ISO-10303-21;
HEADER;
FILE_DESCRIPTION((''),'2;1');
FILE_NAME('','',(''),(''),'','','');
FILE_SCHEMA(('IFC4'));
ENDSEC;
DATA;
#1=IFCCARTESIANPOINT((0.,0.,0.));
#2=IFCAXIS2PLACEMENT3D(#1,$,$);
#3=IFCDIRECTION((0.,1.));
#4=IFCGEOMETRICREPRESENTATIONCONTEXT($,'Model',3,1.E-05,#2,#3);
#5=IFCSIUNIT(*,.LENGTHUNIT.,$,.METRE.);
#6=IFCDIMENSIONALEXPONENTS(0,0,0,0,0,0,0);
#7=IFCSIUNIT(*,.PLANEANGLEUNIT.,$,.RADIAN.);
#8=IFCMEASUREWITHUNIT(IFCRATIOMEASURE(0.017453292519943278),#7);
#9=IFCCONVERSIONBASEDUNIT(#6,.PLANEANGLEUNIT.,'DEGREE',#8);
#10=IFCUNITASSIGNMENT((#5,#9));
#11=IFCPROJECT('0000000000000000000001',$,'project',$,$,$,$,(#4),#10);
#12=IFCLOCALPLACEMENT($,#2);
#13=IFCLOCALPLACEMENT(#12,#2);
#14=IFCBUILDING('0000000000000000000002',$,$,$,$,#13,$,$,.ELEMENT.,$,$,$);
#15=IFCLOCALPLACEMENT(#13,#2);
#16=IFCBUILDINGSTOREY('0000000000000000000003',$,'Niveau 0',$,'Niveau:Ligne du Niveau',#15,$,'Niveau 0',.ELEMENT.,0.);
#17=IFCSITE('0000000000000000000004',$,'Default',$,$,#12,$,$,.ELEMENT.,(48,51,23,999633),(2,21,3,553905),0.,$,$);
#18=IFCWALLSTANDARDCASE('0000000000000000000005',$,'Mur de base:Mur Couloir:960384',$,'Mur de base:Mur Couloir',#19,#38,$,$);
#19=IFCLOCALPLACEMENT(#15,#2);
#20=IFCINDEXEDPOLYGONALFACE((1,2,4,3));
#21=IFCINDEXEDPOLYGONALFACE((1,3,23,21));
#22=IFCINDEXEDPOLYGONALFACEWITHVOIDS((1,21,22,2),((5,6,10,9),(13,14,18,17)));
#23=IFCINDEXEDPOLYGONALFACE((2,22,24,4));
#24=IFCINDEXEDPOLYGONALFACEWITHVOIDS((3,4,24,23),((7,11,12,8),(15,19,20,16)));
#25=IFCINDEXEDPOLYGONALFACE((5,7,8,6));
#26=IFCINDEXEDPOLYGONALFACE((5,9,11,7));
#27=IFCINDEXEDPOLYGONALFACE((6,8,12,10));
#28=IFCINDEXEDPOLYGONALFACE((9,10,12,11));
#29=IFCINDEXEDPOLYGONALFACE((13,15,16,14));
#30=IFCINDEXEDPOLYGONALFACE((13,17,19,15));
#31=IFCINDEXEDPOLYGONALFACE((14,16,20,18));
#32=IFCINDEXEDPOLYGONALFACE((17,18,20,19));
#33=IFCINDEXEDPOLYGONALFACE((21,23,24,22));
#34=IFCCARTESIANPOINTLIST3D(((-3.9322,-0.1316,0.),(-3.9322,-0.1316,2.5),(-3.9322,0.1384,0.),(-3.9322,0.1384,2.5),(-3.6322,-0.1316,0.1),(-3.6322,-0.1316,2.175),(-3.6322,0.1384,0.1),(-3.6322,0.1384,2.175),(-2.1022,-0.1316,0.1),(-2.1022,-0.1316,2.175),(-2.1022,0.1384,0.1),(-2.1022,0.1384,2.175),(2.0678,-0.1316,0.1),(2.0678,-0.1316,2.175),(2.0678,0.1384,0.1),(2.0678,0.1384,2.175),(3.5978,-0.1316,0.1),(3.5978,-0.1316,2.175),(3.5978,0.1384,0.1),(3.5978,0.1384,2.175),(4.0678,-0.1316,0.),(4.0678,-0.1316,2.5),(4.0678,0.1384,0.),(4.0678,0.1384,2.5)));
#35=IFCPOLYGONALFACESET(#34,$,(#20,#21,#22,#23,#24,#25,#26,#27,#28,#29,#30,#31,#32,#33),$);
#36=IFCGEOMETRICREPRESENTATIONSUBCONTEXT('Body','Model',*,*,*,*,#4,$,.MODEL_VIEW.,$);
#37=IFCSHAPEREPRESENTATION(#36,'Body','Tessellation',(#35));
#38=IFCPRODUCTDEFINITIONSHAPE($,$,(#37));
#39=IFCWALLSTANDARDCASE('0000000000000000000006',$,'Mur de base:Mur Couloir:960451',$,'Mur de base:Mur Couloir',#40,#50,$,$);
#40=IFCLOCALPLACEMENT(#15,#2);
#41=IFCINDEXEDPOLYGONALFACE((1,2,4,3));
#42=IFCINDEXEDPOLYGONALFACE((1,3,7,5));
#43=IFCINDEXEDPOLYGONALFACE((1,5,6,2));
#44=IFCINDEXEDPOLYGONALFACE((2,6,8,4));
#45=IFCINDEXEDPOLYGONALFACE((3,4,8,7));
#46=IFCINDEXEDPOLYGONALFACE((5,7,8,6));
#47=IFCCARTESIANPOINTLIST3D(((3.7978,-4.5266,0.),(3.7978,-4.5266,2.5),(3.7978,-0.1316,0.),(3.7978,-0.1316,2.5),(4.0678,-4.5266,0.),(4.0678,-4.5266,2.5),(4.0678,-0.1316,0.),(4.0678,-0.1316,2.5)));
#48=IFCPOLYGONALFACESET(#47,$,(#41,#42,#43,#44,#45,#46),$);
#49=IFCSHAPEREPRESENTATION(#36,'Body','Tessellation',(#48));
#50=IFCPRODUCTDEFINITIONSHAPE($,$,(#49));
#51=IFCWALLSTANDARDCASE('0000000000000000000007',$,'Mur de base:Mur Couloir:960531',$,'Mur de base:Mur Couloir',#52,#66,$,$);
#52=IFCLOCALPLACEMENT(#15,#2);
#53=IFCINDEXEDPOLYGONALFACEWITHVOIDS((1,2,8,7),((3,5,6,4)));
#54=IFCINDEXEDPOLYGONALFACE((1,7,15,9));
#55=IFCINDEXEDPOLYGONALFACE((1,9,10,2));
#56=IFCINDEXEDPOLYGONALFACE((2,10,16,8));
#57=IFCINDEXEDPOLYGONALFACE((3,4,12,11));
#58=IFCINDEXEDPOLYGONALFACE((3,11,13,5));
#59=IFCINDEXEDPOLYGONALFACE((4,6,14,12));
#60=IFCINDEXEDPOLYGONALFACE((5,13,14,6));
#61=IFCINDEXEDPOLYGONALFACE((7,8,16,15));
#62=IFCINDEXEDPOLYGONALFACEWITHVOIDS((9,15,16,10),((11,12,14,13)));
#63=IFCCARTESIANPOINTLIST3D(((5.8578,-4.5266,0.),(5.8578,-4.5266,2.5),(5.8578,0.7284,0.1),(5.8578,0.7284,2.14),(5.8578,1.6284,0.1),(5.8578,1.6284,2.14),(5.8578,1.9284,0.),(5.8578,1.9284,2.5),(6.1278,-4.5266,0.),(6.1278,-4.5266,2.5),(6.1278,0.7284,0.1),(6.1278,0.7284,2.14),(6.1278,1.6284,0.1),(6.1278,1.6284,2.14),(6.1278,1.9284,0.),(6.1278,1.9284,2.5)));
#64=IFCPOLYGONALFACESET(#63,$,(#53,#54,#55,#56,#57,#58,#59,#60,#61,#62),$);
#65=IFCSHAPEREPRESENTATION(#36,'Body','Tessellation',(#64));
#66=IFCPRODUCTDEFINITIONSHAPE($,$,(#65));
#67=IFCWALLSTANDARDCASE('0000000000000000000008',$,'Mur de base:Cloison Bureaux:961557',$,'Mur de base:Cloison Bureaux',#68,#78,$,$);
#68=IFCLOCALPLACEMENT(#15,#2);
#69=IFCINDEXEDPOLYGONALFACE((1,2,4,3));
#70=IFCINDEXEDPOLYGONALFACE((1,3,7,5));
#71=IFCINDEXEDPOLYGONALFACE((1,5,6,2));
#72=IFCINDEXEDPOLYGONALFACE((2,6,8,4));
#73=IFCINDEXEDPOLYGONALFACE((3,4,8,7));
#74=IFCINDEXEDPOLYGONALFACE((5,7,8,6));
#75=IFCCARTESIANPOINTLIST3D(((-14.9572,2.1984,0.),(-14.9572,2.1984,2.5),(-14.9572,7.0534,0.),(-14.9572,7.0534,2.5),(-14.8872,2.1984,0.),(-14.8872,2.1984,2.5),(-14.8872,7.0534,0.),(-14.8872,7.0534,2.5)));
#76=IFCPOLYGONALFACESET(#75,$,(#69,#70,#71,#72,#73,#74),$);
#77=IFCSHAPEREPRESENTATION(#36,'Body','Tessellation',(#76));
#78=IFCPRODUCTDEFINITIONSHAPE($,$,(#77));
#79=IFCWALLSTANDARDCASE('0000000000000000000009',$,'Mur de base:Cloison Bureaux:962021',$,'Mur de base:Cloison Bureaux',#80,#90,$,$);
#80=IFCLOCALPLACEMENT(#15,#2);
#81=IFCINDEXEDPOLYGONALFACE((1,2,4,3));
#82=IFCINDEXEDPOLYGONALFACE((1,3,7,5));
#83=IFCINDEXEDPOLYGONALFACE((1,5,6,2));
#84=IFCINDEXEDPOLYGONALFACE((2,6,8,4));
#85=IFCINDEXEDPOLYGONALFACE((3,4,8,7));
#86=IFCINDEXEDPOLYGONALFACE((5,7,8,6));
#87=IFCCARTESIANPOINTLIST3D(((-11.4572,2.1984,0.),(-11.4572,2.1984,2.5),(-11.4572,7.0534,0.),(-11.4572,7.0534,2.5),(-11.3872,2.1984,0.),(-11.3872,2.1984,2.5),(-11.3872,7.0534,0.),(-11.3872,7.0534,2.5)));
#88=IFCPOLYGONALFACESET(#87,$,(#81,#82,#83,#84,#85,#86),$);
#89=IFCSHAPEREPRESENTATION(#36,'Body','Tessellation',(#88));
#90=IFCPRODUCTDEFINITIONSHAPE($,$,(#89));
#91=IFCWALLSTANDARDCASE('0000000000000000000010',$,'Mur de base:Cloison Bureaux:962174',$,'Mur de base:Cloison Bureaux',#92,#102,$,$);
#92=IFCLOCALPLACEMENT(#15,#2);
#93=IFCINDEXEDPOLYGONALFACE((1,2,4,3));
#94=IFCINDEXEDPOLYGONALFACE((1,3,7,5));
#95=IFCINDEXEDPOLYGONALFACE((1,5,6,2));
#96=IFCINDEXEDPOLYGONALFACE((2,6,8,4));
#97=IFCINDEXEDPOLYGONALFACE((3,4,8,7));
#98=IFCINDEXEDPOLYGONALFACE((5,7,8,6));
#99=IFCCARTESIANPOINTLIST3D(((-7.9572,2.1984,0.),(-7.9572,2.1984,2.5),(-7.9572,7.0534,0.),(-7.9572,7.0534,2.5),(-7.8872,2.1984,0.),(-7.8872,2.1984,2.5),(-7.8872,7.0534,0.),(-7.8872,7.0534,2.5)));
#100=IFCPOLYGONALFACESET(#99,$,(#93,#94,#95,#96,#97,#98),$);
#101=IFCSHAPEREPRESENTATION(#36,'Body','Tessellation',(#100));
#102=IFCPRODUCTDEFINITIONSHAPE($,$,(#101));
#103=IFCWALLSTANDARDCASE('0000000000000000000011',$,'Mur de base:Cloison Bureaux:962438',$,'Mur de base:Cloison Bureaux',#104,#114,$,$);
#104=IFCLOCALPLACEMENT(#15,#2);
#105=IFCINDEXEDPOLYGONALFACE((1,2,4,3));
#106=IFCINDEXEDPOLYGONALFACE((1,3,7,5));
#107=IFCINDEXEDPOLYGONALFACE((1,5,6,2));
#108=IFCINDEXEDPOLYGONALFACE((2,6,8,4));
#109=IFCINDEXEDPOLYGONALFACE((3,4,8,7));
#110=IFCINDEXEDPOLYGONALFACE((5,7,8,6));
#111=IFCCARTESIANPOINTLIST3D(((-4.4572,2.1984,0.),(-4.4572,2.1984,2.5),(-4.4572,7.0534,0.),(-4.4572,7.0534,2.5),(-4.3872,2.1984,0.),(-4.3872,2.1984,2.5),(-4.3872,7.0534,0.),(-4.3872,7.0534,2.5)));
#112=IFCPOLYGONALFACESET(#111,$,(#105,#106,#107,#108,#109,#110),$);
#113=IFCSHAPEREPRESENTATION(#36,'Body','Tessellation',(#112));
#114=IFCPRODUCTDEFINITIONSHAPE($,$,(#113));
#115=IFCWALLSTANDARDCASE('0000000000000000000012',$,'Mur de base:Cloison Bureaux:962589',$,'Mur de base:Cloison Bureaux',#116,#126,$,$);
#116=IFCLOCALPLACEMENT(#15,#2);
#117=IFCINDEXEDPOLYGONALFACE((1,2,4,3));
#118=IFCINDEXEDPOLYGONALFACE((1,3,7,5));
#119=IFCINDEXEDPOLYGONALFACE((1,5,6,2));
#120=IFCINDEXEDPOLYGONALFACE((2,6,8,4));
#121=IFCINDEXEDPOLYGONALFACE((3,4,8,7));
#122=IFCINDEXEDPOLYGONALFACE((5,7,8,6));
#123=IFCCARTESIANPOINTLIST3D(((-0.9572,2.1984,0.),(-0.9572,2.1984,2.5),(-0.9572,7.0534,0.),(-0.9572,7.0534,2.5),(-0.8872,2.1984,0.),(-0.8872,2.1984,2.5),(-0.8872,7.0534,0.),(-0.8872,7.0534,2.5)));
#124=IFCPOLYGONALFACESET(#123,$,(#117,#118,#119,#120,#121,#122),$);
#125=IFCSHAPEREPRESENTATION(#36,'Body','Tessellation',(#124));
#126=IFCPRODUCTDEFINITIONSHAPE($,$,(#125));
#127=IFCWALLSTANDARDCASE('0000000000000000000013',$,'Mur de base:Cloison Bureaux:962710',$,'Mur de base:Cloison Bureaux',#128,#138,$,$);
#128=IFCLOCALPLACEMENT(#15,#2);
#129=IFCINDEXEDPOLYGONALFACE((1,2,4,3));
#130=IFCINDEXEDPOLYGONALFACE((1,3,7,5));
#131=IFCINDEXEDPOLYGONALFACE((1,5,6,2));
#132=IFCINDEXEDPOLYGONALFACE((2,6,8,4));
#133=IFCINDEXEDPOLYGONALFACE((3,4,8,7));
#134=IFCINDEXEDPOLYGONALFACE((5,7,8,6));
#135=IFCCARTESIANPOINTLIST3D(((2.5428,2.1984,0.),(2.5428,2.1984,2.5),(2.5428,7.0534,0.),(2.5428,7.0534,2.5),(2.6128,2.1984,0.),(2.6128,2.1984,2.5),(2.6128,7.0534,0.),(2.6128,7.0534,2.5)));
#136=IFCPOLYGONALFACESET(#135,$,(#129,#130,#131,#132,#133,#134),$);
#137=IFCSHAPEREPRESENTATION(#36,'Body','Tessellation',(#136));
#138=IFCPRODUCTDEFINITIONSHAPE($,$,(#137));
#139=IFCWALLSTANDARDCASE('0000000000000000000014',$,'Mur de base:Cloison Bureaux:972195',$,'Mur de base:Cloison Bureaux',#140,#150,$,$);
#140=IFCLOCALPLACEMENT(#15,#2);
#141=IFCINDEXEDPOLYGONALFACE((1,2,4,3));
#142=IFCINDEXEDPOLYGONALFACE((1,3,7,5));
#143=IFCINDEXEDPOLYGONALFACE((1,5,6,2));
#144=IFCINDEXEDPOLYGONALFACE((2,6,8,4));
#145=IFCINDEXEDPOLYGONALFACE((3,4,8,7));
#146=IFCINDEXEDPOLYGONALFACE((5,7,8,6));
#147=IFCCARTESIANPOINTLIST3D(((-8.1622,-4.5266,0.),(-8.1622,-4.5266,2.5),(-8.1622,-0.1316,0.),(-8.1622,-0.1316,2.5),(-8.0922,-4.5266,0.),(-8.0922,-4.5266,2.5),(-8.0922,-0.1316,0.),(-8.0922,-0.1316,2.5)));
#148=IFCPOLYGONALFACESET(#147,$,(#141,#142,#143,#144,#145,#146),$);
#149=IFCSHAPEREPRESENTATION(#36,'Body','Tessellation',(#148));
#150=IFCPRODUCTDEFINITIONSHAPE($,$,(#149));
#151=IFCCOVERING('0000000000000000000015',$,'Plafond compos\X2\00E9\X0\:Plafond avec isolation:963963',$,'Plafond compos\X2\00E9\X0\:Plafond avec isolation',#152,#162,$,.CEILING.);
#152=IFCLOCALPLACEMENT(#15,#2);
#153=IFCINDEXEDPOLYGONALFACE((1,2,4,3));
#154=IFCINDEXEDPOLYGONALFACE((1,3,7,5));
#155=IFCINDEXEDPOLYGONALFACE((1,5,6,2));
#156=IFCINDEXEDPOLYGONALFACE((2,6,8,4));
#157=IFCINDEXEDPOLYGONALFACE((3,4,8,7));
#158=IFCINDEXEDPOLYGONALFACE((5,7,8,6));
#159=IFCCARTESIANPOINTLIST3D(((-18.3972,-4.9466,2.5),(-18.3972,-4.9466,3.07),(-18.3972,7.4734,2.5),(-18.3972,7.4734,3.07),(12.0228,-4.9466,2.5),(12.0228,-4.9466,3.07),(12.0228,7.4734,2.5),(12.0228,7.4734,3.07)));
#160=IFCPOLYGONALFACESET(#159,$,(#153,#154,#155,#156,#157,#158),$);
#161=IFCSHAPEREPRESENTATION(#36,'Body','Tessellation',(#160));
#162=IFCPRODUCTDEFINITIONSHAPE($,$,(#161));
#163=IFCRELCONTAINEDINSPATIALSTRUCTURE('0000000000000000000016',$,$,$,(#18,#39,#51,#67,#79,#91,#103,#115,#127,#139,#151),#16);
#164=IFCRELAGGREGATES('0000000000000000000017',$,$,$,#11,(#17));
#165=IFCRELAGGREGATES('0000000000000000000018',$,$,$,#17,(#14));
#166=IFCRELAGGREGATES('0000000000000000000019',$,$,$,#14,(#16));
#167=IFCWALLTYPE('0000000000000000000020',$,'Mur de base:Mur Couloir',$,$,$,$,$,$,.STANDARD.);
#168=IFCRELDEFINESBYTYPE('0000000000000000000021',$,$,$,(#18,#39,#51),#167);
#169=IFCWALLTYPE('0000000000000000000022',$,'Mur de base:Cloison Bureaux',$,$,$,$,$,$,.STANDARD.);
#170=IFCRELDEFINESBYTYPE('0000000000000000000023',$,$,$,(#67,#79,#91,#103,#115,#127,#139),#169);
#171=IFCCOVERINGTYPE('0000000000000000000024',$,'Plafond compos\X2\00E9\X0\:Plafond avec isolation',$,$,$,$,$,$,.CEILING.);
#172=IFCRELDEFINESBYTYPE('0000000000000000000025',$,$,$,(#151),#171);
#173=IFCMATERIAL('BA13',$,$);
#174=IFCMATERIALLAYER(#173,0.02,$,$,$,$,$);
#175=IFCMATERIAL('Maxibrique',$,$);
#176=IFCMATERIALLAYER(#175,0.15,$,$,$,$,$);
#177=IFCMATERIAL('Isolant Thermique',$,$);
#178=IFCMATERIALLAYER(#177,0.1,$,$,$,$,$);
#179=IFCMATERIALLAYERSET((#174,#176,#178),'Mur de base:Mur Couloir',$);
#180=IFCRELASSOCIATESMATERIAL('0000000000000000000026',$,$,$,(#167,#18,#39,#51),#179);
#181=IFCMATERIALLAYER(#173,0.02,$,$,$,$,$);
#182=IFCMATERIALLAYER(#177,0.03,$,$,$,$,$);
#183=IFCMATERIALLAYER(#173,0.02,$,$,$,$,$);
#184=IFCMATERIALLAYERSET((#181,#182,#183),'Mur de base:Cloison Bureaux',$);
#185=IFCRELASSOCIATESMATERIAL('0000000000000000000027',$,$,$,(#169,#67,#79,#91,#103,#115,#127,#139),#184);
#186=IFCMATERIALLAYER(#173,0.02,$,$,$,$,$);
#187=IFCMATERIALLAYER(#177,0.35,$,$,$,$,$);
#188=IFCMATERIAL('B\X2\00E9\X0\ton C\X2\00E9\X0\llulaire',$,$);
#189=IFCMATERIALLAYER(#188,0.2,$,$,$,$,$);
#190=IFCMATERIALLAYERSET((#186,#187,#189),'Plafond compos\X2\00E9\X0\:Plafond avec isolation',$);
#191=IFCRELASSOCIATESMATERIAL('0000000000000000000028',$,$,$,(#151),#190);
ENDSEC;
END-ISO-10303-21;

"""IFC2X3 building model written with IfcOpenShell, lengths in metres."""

from ifc_helpers import new_model, entity, si_unit, converted_unit, direction, frame, frame_2d, origin, origin_2d_with_axis, place, context, subcontext, project, spatial, rectangle, extrude, material, layer, layer_set, layer_usage, type_object, element, save


model = new_model("IFC2X3")

# Units and contexts
model_context = context("Model", 3, precision=1e-05, world=origin(), true_north=direction((0.0, 1.0)))
body_context = subcontext(model_context, "Body", "Model", "MODEL_VIEW")
ifc_project = project(units=[si_unit("LENGTHUNIT", "METRE"), converted_unit("PLANEANGLEUNIT", "DEGREE", entity("IfcRatioMeasure", 0.017453292519943278), si_unit("PLANEANGLEUNIT", "RADIAN"), dimensions=[0, 0, 0, 0, 0, 0, 0])], contexts=[model_context])

# Site, building, storey
site_placement = place(None, origin())
site = spatial("IfcSite", under=ifc_project, at=site_placement, Name="Default", CompositionType="ELEMENT", RefLatitude=(48, 51, 23, 999633), RefLongitude=(2, 21, 3, 553905), RefElevation=0.0)
building_placement = place(site_placement, origin())
building = spatial("IfcBuilding", under=site, at=building_placement, CompositionType="ELEMENT")
storey_placement = place(building_placement, origin())
storey = spatial("IfcBuildingStorey", under=building, at=storey_placement, Name="Niveau 0", ObjectType="Niveau:Ligne du Niveau", LongName="Niveau 0", CompositionType="ELEMENT", Elevation=0.0)

# Shared definitions
ifc_material_1 = material(Name="Isolant Thermique")

# Shared definitions
ifc_material_2 = material(Name="BA13")
ifc_layer_1 = layer(ifc_material_2, 0.02)
ifc_material_3 = material(Name="Maxibrique")
ifc_layer_2 = layer(ifc_material_3, 0.15)
ifc_layer_3 = layer(ifc_material_1, 0.1)
ifc_layer_set_1 = layer_set([ifc_layer_1, ifc_layer_2, ifc_layer_3], Name="Mur de base:Mur Couloir")
wall_type_1 = type_object("IfcWallType", Name="Mur de base:Mur Couloir", PredefinedType="STANDARD", material=ifc_layer_set_1)

# Wall, openings
ifc_layer_usage_1 = layer_usage(ifc_layer_set_1, "AXIS2", "NEGATIVE", 0.135)
wall_1_placement = place(storey_placement, frame((-3.9322, 0.0034, 0.0)))
wall_1 = element("IfcWallStandardCase", 1, at=wall_1_placement, inside=storey, type_object=wall_type_1, material=ifc_layer_usage_1, Name="Mur de base:Mur Couloir:960384", ObjectType="Mur de base:Mur Couloir", context=body_context, shape_type="SweptSolid", body=[
    extrude(rectangle(XDim=8.0, YDim=0.27, at=frame_2d((4.0, 0.0), x_axis=(-1.0, 0.0))), origin(), (0.0, 0.0, 1.0), 2.5),
])
opening_1_placement = place(wall_1_placement, frame((1.83, 0.135, 0.1)))
element("IfcOpeningElement", 2, at=opening_1_placement, cuts=wall_1, ObjectType="Opening", context=body_context, shape_type="SweptSolid", body=[
    extrude(rectangle(XDim=2.075, YDim=1.53, at=frame_2d((1.0375, 0.765), x_axis=(1.0, 0.0))), frame((0.0, 0.0, 0.0), z_axis=(0.0, -1.0, 0.0), x_axis=(0.0, 0.0, 1.0)), (0.0, 0.0, 1.0), 0.27),
])
opening_2_placement = place(wall_1_placement, frame((7.53, 0.135, 0.1)))
element("IfcOpeningElement", 3, at=opening_2_placement, cuts=wall_1, ObjectType="Opening", context=body_context, shape_type="SweptSolid", body=[
    extrude(rectangle(XDim=2.075, YDim=1.53, at=frame_2d((1.0375, 0.765), x_axis=(1.0, 0.0))), frame((0.0, 0.0, 0.0), z_axis=(0.0, -1.0, 0.0), x_axis=(0.0, 0.0, 1.0)), (0.0, 0.0, 1.0), 0.27),
])

# Wall
ifc_layer_usage_2 = layer_usage(ifc_layer_set_1, "AXIS2", "NEGATIVE", 0.135)
wall_2_placement = place(storey_placement, frame((3.9328, -0.1316, 0.0), z_axis=(0.0, 0.0, 1.0), x_axis=(0.0, -1.0, 0.0)))
element("IfcWallStandardCase", 4, at=wall_2_placement, inside=storey, type_object=wall_type_1, material=ifc_layer_usage_2, Name="Mur de base:Mur Couloir:960451", ObjectType="Mur de base:Mur Couloir", context=body_context, shape_type="SweptSolid", body=[
    extrude(rectangle(XDim=4.395, YDim=0.27, at=frame_2d((2.1975, 0.0), x_axis=(-1.0, 0.0))), origin(), (0.0, 0.0, 1.0), 2.5),
])

# Wall, opening
ifc_layer_usage_3 = layer_usage(ifc_layer_set_1, "AXIS2", "NEGATIVE", 0.135)
wall_3_placement = place(storey_placement, frame((5.9928, -4.5266, 0.0), z_axis=(0.0, 0.0, 1.0), x_axis=(0.0, 1.0, 0.0)))
wall_3 = element("IfcWallStandardCase", 5, at=wall_3_placement, inside=storey, type_object=wall_type_1, material=ifc_layer_usage_3, Name="Mur de base:Mur Couloir:960531", ObjectType="Mur de base:Mur Couloir", context=body_context, shape_type="SweptSolid", body=[
    extrude(rectangle(XDim=6.455, YDim=0.27, at=frame_2d((3.2275, 0.0), x_axis=(-1.0, 0.0))), origin(), (0.0, 0.0, 1.0), 2.5),
])
opening_3_placement = place(wall_3_placement, frame((4.5266, 5.9928, 0.0), z_axis=(0.0, 0.0, 1.0), x_axis=(0.0, -1.0, 0.0)))
element("IfcOpeningElement", 6, at=opening_3_placement, cuts=wall_3, ObjectType="Opening", context=body_context, shape_type="SweptSolid", body=[
    extrude(rectangle(XDim=2.04, YDim=0.9, at=frame_2d((0.0, 0.0), x_axis=(0.0, 1.0))), frame((6.1278, 1.1784, 1.12), z_axis=(-1.0, 0.0, 0.0), x_axis=(0.0, 1.0, 0.0)), (0.0, 0.0, 1.0), 0.27),
])

# Walls
ifc_layer_4 = layer(ifc_material_2, 0.02)
ifc_layer_5 = layer(ifc_material_1, 0.03)
ifc_layer_6 = layer(ifc_material_2, 0.02)
ifc_layer_set_2 = layer_set([ifc_layer_4, ifc_layer_5, ifc_layer_6], Name="Mur de base:Cloison Bureaux")
ifc_layer_usage_4 = layer_usage(ifc_layer_set_2, "AXIS2", "NEGATIVE", 0.035)
wall_type_2 = type_object("IfcWallType", Name="Mur de base:Cloison Bureaux", PredefinedType="STANDARD", material=ifc_layer_set_2)
wall_4_placement = place(storey_placement, frame((-14.9222, 2.1984, 0.0), z_axis=(0.0, 0.0, 1.0), x_axis=(0.0, 1.0, 0.0)))
element("IfcWallStandardCase", 7, at=wall_4_placement, inside=storey, type_object=wall_type_2, material=ifc_layer_usage_4, Name="Mur de base:Cloison Bureaux:961557", ObjectType="Mur de base:Cloison Bureaux", context=body_context, shape_type="SweptSolid", body=[
    extrude(rectangle(XDim=4.855, YDim=0.07, at=frame_2d((2.4275, 0.0), x_axis=(-1.0, 0.0))), origin(), (0.0, 0.0, 1.0), 2.5),
])
ifc_layer_usage_5 = layer_usage(ifc_layer_set_2, "AXIS2", "NEGATIVE", 0.035)
wall_5_placement = place(storey_placement, frame((-11.4222, 2.1984, 0.0), z_axis=(0.0, 0.0, 1.0), x_axis=(0.0, 1.0, 0.0)))
element("IfcWallStandardCase", 8, at=wall_5_placement, inside=storey, type_object=wall_type_2, material=ifc_layer_usage_5, Name="Mur de base:Cloison Bureaux:962021", ObjectType="Mur de base:Cloison Bureaux", context=body_context, shape_type="SweptSolid", body=[
    extrude(rectangle(XDim=4.855, YDim=0.07, at=frame_2d((2.4275, 0.0), x_axis=(-1.0, 0.0))), origin(), (0.0, 0.0, 1.0), 2.5),
])
ifc_layer_usage_6 = layer_usage(ifc_layer_set_2, "AXIS2", "NEGATIVE", 0.035)
wall_6_placement = place(storey_placement, frame((-7.9222, 2.1984, 0.0), z_axis=(0.0, 0.0, 1.0), x_axis=(0.0, 1.0, 0.0)))
element("IfcWallStandardCase", 9, at=wall_6_placement, inside=storey, type_object=wall_type_2, material=ifc_layer_usage_6, Name="Mur de base:Cloison Bureaux:962174", ObjectType="Mur de base:Cloison Bureaux", context=body_context, shape_type="SweptSolid", body=[
    extrude(rectangle(XDim=4.855, YDim=0.07, at=frame_2d((2.4275, 0.0), x_axis=(-1.0, 0.0))), origin(), (0.0, 0.0, 1.0), 2.5),
])
ifc_layer_usage_7 = layer_usage(ifc_layer_set_2, "AXIS2", "NEGATIVE", 0.035)
wall_7_placement = place(storey_placement, frame((-4.4222, 2.1984, 0.0), z_axis=(0.0, 0.0, 1.0), x_axis=(0.0, 1.0, 0.0)))
element("IfcWallStandardCase", 10, at=wall_7_placement, inside=storey, type_object=wall_type_2, material=ifc_layer_usage_7, Name="Mur de base:Cloison Bureaux:962438", ObjectType="Mur de base:Cloison Bureaux", context=body_context, shape_type="SweptSolid", body=[
    extrude(rectangle(XDim=4.855, YDim=0.07, at=frame_2d((2.4275, 0.0), x_axis=(-1.0, 0.0))), origin(), (0.0, 0.0, 1.0), 2.5),
])
ifc_layer_usage_8 = layer_usage(ifc_layer_set_2, "AXIS2", "NEGATIVE", 0.035)
wall_8_placement = place(storey_placement, frame((-0.9222, 2.1984, 0.0), z_axis=(0.0, 0.0, 1.0), x_axis=(0.0, 1.0, 0.0)))
element("IfcWallStandardCase", 11, at=wall_8_placement, inside=storey, type_object=wall_type_2, material=ifc_layer_usage_8, Name="Mur de base:Cloison Bureaux:962589", ObjectType="Mur de base:Cloison Bureaux", context=body_context, shape_type="SweptSolid", body=[
    extrude(rectangle(XDim=4.855, YDim=0.07, at=frame_2d((2.4275, 0.0), x_axis=(-1.0, 0.0))), origin(), (0.0, 0.0, 1.0), 2.5),
])
ifc_layer_usage_9 = layer_usage(ifc_layer_set_2, "AXIS2", "NEGATIVE", 0.035)
wall_9_placement = place(storey_placement, frame((2.5778, 2.1984, 0.0), z_axis=(0.0, 0.0, 1.0), x_axis=(0.0, 1.0, 0.0)))
element("IfcWallStandardCase", 12, at=wall_9_placement, inside=storey, type_object=wall_type_2, material=ifc_layer_usage_9, Name="Mur de base:Cloison Bureaux:962710", ObjectType="Mur de base:Cloison Bureaux", context=body_context, shape_type="SweptSolid", body=[
    extrude(rectangle(XDim=4.855, YDim=0.07, at=frame_2d((2.4275, 0.0), x_axis=(-1.0, 0.0))), origin(), (0.0, 0.0, 1.0), 2.5),
])
ifc_layer_usage_10 = layer_usage(ifc_layer_set_2, "AXIS2", "NEGATIVE", 0.035)
wall_10_placement = place(storey_placement, frame((-8.1272, -0.1316, 0.0), z_axis=(0.0, 0.0, 1.0), x_axis=(0.0, -1.0, 0.0)))
element("IfcWallStandardCase", 13, at=wall_10_placement, inside=storey, type_object=wall_type_2, material=ifc_layer_usage_10, Name="Mur de base:Cloison Bureaux:972195", ObjectType="Mur de base:Cloison Bureaux", context=body_context, shape_type="SweptSolid", body=[
    extrude(rectangle(XDim=4.395, YDim=0.07, at=frame_2d((2.1975, 0.0), x_axis=(-1.0, 0.0))), origin(), (0.0, 0.0, 1.0), 2.5),
])

# Covering
ifc_layer_7 = layer(ifc_material_2, 0.02)
ifc_layer_8 = layer(ifc_material_1, 0.35)
ifc_material_4 = material(Name="Béton Céllulaire")
ifc_layer_9 = layer(ifc_material_4, 0.2)
ifc_layer_set_3 = layer_set([ifc_layer_7, ifc_layer_8, ifc_layer_9], Name="Plafond composé:Plafond avec isolation")
ifc_layer_usage_11 = layer_usage(ifc_layer_set_3, "AXIS3", "POSITIVE", 0.0)
covering_type = type_object("IfcCoveringType", Name="Plafond composé:Plafond avec isolation", PredefinedType="CEILING")
covering_placement = place(storey_placement, origin())
element("IfcCovering", 14, at=covering_placement, inside=storey, type_object=covering_type, material=ifc_layer_usage_11, Name="Plafond composé:Plafond avec isolation:963963", ObjectType="Plafond composé:Plafond avec isolation", PredefinedType="CEILING", context=body_context, shape_type="SweptSolid", body=[
    extrude(rectangle(XDim=30.42, YDim=12.42, at=origin_2d_with_axis()), frame((-3.1872, 1.2634, 2.5)), (0.0, 0.0, 1.0), 0.57),
])

save(model, "model.ifc")
